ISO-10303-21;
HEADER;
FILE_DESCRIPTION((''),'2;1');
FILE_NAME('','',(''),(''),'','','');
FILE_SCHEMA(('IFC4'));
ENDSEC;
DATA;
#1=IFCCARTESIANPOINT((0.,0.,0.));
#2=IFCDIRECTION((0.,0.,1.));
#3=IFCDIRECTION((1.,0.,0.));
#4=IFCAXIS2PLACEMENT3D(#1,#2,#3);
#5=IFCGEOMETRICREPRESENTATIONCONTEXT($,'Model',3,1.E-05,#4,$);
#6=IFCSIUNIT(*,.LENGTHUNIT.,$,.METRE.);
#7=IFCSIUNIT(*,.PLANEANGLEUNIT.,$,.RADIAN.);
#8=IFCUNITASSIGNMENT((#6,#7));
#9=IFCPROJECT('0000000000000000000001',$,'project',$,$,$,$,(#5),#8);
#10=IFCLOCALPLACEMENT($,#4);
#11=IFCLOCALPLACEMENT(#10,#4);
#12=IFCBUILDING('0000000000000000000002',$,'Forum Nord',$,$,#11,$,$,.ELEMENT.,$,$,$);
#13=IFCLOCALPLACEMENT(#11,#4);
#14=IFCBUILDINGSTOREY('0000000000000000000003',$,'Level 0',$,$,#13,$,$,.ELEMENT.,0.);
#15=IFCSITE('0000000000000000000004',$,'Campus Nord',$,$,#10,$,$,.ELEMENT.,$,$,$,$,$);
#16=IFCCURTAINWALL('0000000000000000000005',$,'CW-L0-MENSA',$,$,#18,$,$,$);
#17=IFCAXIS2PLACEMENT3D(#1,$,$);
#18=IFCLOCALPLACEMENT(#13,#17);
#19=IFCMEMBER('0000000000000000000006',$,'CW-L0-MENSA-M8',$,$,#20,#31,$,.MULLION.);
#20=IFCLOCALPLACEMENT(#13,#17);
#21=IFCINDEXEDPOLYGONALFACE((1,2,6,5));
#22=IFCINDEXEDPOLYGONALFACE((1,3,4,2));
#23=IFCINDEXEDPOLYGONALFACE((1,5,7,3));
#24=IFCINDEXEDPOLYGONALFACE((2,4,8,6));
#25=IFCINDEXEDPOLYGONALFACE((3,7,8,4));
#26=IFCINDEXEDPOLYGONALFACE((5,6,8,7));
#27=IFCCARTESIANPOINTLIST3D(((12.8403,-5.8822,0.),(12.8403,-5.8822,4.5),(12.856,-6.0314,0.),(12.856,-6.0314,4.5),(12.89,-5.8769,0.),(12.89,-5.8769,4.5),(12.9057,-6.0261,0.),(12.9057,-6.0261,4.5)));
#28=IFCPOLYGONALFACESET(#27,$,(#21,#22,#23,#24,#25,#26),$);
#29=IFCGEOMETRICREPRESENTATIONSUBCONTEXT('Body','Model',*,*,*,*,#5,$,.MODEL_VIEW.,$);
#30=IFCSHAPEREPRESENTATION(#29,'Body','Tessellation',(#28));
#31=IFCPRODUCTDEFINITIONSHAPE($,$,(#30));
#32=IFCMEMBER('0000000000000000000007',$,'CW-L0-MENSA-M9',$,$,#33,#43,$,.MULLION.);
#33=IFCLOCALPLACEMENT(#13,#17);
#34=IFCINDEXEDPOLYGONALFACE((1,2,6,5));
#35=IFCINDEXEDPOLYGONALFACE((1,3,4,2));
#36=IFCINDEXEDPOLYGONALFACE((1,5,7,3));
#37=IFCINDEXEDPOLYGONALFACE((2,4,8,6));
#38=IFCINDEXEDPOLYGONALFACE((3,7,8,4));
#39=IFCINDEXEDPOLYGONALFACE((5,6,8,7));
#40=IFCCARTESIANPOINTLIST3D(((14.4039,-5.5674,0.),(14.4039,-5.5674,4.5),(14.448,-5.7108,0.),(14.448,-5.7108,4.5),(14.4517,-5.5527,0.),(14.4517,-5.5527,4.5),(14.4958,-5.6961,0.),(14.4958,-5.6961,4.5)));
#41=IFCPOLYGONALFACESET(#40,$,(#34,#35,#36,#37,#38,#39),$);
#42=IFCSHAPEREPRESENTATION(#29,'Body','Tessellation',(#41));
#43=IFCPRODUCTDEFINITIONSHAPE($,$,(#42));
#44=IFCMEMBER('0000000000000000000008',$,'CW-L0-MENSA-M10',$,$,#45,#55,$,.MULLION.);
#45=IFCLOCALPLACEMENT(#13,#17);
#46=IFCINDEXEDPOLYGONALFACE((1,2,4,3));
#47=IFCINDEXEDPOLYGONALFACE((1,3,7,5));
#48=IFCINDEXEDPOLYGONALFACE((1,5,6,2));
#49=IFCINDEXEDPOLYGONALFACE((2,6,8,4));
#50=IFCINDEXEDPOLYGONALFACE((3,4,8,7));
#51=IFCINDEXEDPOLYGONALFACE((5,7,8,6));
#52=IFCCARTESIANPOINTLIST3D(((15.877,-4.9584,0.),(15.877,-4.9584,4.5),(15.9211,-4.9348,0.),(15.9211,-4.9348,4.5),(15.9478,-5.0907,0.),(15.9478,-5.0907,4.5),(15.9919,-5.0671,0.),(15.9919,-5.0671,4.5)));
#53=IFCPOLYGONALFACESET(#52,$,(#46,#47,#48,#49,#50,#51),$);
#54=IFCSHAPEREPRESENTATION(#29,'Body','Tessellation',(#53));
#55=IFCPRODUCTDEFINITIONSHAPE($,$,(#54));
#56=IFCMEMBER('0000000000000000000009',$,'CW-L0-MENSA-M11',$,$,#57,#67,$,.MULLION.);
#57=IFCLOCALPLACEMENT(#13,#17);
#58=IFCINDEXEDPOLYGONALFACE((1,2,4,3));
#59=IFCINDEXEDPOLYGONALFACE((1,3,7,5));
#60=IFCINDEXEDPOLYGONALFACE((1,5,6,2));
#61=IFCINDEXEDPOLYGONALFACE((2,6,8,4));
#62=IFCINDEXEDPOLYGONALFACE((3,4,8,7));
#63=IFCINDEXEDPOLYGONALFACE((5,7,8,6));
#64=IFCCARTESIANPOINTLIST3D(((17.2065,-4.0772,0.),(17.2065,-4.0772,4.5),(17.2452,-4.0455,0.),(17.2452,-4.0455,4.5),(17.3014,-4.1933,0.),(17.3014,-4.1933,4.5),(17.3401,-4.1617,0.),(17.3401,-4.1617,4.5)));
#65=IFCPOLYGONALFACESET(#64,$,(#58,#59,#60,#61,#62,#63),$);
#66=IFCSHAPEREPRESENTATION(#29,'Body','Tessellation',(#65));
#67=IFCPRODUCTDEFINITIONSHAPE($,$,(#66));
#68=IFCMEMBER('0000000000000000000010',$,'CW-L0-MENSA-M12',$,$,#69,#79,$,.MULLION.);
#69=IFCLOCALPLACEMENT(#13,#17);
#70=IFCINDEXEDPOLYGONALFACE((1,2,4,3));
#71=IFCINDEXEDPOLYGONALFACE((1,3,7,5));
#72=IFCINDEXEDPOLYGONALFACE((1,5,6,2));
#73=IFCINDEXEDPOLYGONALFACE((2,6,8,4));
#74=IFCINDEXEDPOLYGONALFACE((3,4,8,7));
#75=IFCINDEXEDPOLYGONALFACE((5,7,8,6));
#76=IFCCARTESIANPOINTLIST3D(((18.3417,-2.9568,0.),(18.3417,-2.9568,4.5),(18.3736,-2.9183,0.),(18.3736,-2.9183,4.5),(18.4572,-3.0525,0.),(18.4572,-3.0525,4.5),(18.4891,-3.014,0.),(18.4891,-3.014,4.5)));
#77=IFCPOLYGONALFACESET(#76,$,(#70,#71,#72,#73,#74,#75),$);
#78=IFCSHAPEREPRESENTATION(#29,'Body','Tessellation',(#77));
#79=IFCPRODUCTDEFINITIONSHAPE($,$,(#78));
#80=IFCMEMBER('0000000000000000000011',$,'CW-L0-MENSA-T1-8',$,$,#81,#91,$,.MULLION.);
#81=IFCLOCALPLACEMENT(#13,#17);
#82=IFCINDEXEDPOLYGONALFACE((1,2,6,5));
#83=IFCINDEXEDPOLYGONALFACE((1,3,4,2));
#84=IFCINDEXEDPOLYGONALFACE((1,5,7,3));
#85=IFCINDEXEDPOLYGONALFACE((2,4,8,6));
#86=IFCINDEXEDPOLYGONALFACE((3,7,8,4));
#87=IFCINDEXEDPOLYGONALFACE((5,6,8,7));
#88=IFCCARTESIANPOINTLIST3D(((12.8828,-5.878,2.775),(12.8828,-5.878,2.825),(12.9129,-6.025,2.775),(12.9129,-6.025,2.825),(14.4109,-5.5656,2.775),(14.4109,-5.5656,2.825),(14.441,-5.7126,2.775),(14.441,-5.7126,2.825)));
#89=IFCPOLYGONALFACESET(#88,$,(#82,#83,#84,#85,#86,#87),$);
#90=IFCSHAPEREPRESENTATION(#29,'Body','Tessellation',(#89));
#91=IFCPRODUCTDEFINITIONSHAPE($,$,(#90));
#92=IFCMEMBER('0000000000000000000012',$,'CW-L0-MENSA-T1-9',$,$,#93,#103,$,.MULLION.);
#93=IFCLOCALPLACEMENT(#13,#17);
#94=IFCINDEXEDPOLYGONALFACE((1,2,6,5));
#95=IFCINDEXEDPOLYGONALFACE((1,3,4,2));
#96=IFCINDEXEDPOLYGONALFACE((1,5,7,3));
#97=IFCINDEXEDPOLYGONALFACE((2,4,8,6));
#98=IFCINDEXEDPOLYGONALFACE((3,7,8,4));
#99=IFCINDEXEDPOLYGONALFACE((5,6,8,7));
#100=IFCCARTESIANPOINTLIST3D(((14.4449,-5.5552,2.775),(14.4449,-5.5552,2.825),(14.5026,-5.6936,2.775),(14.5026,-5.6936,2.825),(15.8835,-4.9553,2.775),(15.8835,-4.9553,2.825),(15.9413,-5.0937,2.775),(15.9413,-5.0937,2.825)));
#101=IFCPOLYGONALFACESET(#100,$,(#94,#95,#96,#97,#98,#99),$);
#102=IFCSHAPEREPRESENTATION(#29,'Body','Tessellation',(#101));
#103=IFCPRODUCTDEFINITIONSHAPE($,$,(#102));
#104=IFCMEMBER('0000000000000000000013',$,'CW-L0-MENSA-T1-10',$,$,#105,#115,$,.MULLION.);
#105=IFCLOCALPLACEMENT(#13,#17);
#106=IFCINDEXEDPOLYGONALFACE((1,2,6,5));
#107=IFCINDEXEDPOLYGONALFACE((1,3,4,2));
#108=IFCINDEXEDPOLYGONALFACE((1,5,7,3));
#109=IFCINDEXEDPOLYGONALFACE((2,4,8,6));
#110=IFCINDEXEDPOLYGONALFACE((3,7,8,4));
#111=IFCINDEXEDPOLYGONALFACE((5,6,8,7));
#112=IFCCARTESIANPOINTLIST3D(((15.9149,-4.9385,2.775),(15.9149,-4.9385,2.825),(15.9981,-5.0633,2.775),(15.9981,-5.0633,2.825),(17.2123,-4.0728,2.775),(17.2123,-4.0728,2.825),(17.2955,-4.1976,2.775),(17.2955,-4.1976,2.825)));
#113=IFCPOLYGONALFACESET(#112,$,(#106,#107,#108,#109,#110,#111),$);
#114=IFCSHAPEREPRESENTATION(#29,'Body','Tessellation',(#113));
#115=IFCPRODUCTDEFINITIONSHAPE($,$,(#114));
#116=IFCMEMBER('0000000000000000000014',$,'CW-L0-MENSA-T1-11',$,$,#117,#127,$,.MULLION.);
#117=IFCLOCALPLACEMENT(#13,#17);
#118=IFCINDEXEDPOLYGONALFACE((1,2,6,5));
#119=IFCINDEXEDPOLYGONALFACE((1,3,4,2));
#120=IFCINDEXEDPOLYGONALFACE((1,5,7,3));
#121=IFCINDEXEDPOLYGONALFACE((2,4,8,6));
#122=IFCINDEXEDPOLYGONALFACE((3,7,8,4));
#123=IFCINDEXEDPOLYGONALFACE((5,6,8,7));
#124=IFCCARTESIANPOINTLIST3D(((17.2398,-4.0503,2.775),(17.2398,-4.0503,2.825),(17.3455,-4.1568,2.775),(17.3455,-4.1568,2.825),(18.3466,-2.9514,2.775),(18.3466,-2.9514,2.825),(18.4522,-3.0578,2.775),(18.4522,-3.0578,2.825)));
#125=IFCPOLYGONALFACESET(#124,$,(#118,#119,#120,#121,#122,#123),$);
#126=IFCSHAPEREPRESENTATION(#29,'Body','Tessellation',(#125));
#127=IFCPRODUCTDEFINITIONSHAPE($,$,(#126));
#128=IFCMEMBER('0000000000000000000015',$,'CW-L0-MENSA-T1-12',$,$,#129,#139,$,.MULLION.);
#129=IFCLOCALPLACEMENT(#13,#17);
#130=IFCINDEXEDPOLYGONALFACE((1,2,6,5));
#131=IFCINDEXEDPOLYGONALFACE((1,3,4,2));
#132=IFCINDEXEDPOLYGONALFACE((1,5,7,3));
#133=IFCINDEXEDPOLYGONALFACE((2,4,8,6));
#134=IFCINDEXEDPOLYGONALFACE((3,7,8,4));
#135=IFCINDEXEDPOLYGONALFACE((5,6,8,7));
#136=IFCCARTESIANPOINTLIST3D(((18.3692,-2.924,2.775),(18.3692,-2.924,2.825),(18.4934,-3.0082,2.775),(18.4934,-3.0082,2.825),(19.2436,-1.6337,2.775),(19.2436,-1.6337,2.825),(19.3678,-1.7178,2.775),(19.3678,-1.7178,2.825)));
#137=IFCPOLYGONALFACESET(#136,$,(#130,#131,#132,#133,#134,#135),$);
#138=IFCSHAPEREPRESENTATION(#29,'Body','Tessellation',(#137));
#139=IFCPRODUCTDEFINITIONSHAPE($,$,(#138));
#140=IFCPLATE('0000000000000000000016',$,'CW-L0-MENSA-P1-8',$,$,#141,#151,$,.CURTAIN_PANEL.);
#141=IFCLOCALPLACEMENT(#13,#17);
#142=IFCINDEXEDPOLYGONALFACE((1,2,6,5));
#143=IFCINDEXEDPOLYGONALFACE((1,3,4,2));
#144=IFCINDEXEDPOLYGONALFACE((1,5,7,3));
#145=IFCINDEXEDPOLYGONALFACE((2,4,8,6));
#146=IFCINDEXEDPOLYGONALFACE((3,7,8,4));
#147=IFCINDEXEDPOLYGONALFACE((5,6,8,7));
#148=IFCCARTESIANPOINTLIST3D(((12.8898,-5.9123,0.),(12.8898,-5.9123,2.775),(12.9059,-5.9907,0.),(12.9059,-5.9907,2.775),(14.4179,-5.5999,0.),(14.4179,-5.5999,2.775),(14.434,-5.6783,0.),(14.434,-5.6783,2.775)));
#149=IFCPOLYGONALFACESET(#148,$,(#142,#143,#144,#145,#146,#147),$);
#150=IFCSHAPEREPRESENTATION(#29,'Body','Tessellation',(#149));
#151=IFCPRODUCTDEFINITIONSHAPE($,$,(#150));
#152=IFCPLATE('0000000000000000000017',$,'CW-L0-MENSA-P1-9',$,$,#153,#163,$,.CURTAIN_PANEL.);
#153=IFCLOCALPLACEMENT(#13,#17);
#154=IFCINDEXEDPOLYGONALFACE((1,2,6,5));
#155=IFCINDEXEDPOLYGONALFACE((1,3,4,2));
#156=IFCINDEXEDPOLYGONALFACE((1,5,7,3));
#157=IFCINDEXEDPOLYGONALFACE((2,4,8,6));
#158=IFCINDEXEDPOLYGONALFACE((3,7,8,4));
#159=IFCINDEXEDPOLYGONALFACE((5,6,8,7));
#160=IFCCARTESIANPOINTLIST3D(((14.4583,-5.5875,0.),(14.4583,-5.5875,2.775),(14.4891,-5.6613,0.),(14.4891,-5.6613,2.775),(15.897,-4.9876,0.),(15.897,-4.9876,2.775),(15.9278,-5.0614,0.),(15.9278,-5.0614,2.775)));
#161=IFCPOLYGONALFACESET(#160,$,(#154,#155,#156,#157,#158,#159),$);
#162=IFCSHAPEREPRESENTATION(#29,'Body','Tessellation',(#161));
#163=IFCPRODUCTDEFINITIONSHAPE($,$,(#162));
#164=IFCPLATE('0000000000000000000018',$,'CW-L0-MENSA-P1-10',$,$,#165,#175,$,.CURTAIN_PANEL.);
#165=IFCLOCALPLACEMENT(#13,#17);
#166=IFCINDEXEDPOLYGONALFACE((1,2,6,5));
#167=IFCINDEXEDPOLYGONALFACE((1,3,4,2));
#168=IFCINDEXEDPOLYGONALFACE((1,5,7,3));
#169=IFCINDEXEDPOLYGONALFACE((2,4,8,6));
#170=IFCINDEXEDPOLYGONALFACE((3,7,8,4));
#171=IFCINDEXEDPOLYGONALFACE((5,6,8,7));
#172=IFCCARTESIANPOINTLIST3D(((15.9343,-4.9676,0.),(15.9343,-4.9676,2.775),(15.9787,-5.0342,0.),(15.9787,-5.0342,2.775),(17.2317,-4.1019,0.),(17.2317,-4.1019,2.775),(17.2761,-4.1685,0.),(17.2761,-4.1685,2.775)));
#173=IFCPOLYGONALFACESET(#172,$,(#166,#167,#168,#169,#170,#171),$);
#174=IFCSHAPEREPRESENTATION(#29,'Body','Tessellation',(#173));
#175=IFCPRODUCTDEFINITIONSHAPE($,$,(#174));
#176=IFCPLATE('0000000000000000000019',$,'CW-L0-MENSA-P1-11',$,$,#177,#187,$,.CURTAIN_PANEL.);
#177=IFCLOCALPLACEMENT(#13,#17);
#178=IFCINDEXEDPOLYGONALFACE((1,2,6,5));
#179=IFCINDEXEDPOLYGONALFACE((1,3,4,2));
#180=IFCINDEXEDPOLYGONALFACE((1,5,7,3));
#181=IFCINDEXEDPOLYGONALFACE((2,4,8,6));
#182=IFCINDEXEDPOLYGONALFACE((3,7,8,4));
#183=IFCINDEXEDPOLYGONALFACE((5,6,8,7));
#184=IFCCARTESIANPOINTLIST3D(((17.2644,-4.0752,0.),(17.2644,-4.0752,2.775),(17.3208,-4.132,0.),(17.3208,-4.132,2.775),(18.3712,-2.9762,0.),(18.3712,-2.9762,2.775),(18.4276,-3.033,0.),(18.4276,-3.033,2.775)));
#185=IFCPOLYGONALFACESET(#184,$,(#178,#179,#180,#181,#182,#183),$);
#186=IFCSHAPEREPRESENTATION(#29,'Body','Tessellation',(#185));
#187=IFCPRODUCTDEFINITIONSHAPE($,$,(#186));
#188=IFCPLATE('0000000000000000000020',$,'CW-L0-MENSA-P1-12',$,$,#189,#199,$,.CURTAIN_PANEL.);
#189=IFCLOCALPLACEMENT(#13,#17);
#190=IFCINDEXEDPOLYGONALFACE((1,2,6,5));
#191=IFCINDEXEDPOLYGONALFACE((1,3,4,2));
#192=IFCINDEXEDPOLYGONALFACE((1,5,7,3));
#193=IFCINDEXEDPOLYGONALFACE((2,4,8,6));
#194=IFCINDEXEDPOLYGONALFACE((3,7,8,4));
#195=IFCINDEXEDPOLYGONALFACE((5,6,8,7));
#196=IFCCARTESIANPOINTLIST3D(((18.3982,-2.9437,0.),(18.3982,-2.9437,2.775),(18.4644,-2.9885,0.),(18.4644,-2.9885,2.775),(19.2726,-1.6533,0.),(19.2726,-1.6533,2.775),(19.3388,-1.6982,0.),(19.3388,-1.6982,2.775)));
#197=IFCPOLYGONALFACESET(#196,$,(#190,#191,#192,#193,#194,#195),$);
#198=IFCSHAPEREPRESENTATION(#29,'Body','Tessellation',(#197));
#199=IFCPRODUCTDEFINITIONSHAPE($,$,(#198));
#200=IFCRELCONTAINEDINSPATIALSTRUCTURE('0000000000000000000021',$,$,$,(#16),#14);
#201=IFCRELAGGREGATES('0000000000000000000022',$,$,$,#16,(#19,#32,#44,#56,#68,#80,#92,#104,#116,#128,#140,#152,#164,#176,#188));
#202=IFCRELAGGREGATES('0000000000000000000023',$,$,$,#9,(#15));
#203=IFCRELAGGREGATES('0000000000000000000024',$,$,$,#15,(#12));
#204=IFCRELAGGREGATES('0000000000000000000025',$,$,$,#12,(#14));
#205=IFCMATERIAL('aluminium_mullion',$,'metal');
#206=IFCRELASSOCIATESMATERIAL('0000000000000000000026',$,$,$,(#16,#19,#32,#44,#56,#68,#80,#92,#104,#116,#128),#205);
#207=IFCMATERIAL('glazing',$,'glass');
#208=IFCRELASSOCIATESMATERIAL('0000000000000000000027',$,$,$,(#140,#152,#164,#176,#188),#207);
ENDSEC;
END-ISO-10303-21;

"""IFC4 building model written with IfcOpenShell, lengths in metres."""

from ifc_helpers import new_model, si_unit, frame, frame_2d, origin_with_axes, origin_2d_with_axis, place, context, subcontext, project, spatial, rectangle, extrude, material, element, aggregate, save


model = new_model("IFC4")

# Units and contexts
model_context = context("Model", 3, precision=1e-05, world=origin_with_axes())
body_context = subcontext(model_context, "Body", "Model", "MODEL_VIEW")
ifc_project = project(units=[si_unit("LENGTHUNIT", "METRE"), si_unit("PLANEANGLEUNIT", "RADIAN")], contexts=[model_context])

# Site, building, storey
site_placement = place(None, origin_with_axes())
site = spatial("IfcSite", under=ifc_project, at=site_placement, Name="Campus Nord", CompositionType="ELEMENT")
building_placement = place(site_placement, origin_with_axes())
building = spatial("IfcBuilding", under=site, at=building_placement, Name="Forum Nord", CompositionType="ELEMENT")
storey_placement = place(building_placement, origin_with_axes())
storey = spatial("IfcBuildingStorey", under=building, at=storey_placement, Name="Level 0", CompositionType="ELEMENT", Elevation=0.0)

# Curtain wall, members, plates
ifc_material_1 = material(Name="aluminium_mullion", Category="metal")
curtain_wall_placement = place(storey_placement, origin_with_axes())
curtain_wall = element("IfcCurtainWall", 1, at=curtain_wall_placement, inside=storey, material=ifc_material_1, Name="CW-L0-MENSA")
member_1_placement = place(storey_placement, frame((12.873, -5.9542, 0.0), z_axis=(0.0, 0.0, 1.0), x_axis=(0.9945, 0.10476, 0.0)))
member_1 = element("IfcMember", 2, at=member_1_placement, material=ifc_material_1, Name="CW-L0-MENSA-M8", PredefinedType="MULLION", context=body_context, shape_type="SweptSolid", body=[
    extrude(rectangle(XDim=0.05, YDim=0.15, at=origin_2d_with_axis()), origin_with_axes(), (0.0, 0.0, 1.0), 4.5),
])
member_2_placement = place(storey_placement, frame((14.4499, -5.6318, 0.0), z_axis=(0.0, 0.0, 1.0), x_axis=(0.95581, 0.29397, 0.0)))
member_2 = element("IfcMember", 3, at=member_2_placement, material=ifc_material_1, Name="CW-L0-MENSA-M9", PredefinedType="MULLION", context=body_context, shape_type="SweptSolid", body=[
    extrude(rectangle(XDim=0.05, YDim=0.15, at=origin_2d_with_axis()), origin_with_axes(), (0.0, 0.0, 1.0), 4.5),
])
member_3_placement = place(storey_placement, frame((15.9345, -5.0127, 0.0), z_axis=(0.0, 0.0, 1.0), x_axis=(0.88153, 0.47212, 0.0)))
member_3 = element("IfcMember", 4, at=member_3_placement, material=ifc_material_1, Name="CW-L0-MENSA-M10", PredefinedType="MULLION", context=body_context, shape_type="SweptSolid", body=[
    extrude(rectangle(XDim=0.05, YDim=0.15, at=origin_2d_with_axis()), origin_with_axes(), (0.0, 0.0, 1.0), 4.5),
])
member_4_placement = place(storey_placement, frame((17.2733, -4.1194, 0.0), z_axis=(0.0, 0.0, 1.0), x_axis=(0.77434, 0.63277, 0.0)))
member_4 = element("IfcMember", 5, at=member_4_placement, material=ifc_material_1, Name="CW-L0-MENSA-M11", PredefinedType="MULLION", context=body_context, shape_type="SweptSolid", body=[
    extrude(rectangle(XDim=0.05, YDim=0.15, at=origin_2d_with_axis()), origin_with_axes(), (0.0, 0.0, 1.0), 4.5),
])
member_5_placement = place(storey_placement, frame((18.4154, -2.9854, 0.0), z_axis=(0.0, 0.0, 1.0), x_axis=(0.63826, 0.76982, 0.0)))
member_5 = element("IfcMember", 6, at=member_5_placement, material=ifc_material_1, Name="CW-L0-MENSA-M12", PredefinedType="MULLION", context=body_context, shape_type="SweptSolid", body=[
    extrude(rectangle(XDim=0.05, YDim=0.15, at=origin_2d_with_axis()), origin_with_axes(), (0.0, 0.0, 1.0), 4.5),
])
member_6_placement = place(storey_placement, frame((12.8979, -5.9515, 2.8), z_axis=(0.97973, 0.2003, 0.0), x_axis=(-0.2003, 0.97973, 0.0)))
member_6 = element("IfcMember", 7, at=member_6_placement, material=ifc_material_1, Name="CW-L0-MENSA-T1-8", PredefinedType="MULLION", context=body_context, shape_type="SweptSolid", body=[
    extrude(rectangle(XDim=0.15, YDim=0.05, at=origin_2d_with_axis()), origin_with_axes(), (0.0, 0.0, 1.0), 1.5597),
])
member_7_placement = place(storey_placement, frame((14.4737, -5.6244, 2.8), z_axis=(0.92298, 0.38484, 0.0), x_axis=(-0.38484, 0.92298, 0.0)))
member_7 = element("IfcMember", 8, at=member_7_placement, material=ifc_material_1, Name="CW-L0-MENSA-T1-9", PredefinedType="MULLION", context=body_context, shape_type="SweptSolid", body=[
    extrude(rectangle(XDim=0.15, YDim=0.05, at=origin_2d_with_axis()), origin_with_axes(), (0.0, 0.0, 1.0), 1.5587),
])
member_8_placement = place(storey_placement, frame((15.9565, -5.0009, 2.8), z_axis=(0.83182, 0.55504, 0.0), x_axis=(-0.55504, 0.83182, 0.0)))
member_8 = element("IfcMember", 9, at=member_8_placement, material=ifc_material_1, Name="CW-L0-MENSA-T1-10", PredefinedType="MULLION", context=body_context, shape_type="SweptSolid", body=[
    extrude(rectangle(XDim=0.15, YDim=0.05, at=origin_2d_with_axis()), origin_with_axes(), (0.0, 0.0, 1.0), 1.5597),
])
member_9_placement = place(storey_placement, frame((17.2926, -4.1036, 2.8), z_axis=(0.70961, 0.70459, 0.0), x_axis=(-0.70459, 0.70961, 0.0)))
member_9 = element("IfcMember", 10, at=member_9_placement, material=ifc_material_1, Name="CW-L0-MENSA-T1-11", PredefinedType="MULLION", context=body_context, shape_type="SweptSolid", body=[
    extrude(rectangle(XDim=0.15, YDim=0.05, at=origin_2d_with_axis()), origin_with_axes(), (0.0, 0.0, 1.0), 1.5597),
])
member_10_placement = place(storey_placement, frame((18.4313, -2.9661, 2.8), z_axis=(0.56098, 0.82783, 0.0), x_axis=(-0.82783, 0.56098, 0.0)))
member_10 = element("IfcMember", 11, at=member_10_placement, material=ifc_material_1, Name="CW-L0-MENSA-T1-12", PredefinedType="MULLION", context=body_context, shape_type="SweptSolid", body=[
    extrude(rectangle(XDim=0.15, YDim=0.05, at=origin_2d_with_axis()), origin_with_axes(), (0.0, 0.0, 1.0), 1.5587),
])
ifc_material_2 = material(Name="glazing", Category="glass")
plate_1_placement = place(storey_placement, frame((12.8979, -5.9515, 0.0), z_axis=(0.0, 0.0, 1.0), x_axis=(0.97973, 0.2003, 0.0)))
plate_1 = element("IfcPlate", 12, at=plate_1_placement, material=ifc_material_2, Name="CW-L0-MENSA-P1-8", PredefinedType="CURTAIN_PANEL", context=body_context, shape_type="SweptSolid", body=[
    extrude(rectangle(XDim=1.5597, YDim=0.08, at=frame_2d((0.7799, 0.0), x_axis=(1.0, 0.0))), origin_with_axes(), (0.0, 0.0, 1.0), 2.775),
])
plate_2_placement = place(storey_placement, frame((14.4737, -5.6244, 0.0), z_axis=(0.0, 0.0, 1.0), x_axis=(0.92298, 0.38484, 0.0)))
plate_2 = element("IfcPlate", 13, at=plate_2_placement, material=ifc_material_2, Name="CW-L0-MENSA-P1-9", PredefinedType="CURTAIN_PANEL", context=body_context, shape_type="SweptSolid", body=[
    extrude(rectangle(XDim=1.5587, YDim=0.08, at=frame_2d((0.7794, 0.0), x_axis=(1.0, 0.0))), origin_with_axes(), (0.0, 0.0, 1.0), 2.775),
])
plate_3_placement = place(storey_placement, frame((15.9565, -5.0009, 0.0), z_axis=(0.0, 0.0, 1.0), x_axis=(0.83182, 0.55504, 0.0)))
plate_3 = element("IfcPlate", 14, at=plate_3_placement, material=ifc_material_2, Name="CW-L0-MENSA-P1-10", PredefinedType="CURTAIN_PANEL", context=body_context, shape_type="SweptSolid", body=[
    extrude(rectangle(XDim=1.5597, YDim=0.08, at=frame_2d((0.7799, 0.0), x_axis=(1.0, 0.0))), origin_with_axes(), (0.0, 0.0, 1.0), 2.775),
])
plate_4_placement = place(storey_placement, frame((17.2926, -4.1036, 0.0), z_axis=(0.0, 0.0, 1.0), x_axis=(0.70961, 0.70459, 0.0)))
plate_4 = element("IfcPlate", 15, at=plate_4_placement, material=ifc_material_2, Name="CW-L0-MENSA-P1-11", PredefinedType="CURTAIN_PANEL", context=body_context, shape_type="SweptSolid", body=[
    extrude(rectangle(XDim=1.5597, YDim=0.08, at=frame_2d((0.7799, 0.0), x_axis=(1.0, 0.0))), origin_with_axes(), (0.0, 0.0, 1.0), 2.775),
])
plate_5_placement = place(storey_placement, frame((18.4313, -2.9661, 0.0), z_axis=(0.0, 0.0, 1.0), x_axis=(0.56098, 0.82783, 0.0)))
plate_5 = element("IfcPlate", 16, at=plate_5_placement, material=ifc_material_2, Name="CW-L0-MENSA-P1-12", PredefinedType="CURTAIN_PANEL", context=body_context, shape_type="SweptSolid", body=[
    extrude(rectangle(XDim=1.5587, YDim=0.08, at=frame_2d((0.7794, 0.0), x_axis=(1.0, 0.0))), origin_with_axes(), (0.0, 0.0, 1.0), 2.775),
])
aggregate(curtain_wall, [member_1, member_2, member_3, member_4, member_5, member_6, member_7, member_8, member_9, member_10, plate_1, plate_2, plate_3, plate_4, plate_5])

save(model, "model.ifc")
